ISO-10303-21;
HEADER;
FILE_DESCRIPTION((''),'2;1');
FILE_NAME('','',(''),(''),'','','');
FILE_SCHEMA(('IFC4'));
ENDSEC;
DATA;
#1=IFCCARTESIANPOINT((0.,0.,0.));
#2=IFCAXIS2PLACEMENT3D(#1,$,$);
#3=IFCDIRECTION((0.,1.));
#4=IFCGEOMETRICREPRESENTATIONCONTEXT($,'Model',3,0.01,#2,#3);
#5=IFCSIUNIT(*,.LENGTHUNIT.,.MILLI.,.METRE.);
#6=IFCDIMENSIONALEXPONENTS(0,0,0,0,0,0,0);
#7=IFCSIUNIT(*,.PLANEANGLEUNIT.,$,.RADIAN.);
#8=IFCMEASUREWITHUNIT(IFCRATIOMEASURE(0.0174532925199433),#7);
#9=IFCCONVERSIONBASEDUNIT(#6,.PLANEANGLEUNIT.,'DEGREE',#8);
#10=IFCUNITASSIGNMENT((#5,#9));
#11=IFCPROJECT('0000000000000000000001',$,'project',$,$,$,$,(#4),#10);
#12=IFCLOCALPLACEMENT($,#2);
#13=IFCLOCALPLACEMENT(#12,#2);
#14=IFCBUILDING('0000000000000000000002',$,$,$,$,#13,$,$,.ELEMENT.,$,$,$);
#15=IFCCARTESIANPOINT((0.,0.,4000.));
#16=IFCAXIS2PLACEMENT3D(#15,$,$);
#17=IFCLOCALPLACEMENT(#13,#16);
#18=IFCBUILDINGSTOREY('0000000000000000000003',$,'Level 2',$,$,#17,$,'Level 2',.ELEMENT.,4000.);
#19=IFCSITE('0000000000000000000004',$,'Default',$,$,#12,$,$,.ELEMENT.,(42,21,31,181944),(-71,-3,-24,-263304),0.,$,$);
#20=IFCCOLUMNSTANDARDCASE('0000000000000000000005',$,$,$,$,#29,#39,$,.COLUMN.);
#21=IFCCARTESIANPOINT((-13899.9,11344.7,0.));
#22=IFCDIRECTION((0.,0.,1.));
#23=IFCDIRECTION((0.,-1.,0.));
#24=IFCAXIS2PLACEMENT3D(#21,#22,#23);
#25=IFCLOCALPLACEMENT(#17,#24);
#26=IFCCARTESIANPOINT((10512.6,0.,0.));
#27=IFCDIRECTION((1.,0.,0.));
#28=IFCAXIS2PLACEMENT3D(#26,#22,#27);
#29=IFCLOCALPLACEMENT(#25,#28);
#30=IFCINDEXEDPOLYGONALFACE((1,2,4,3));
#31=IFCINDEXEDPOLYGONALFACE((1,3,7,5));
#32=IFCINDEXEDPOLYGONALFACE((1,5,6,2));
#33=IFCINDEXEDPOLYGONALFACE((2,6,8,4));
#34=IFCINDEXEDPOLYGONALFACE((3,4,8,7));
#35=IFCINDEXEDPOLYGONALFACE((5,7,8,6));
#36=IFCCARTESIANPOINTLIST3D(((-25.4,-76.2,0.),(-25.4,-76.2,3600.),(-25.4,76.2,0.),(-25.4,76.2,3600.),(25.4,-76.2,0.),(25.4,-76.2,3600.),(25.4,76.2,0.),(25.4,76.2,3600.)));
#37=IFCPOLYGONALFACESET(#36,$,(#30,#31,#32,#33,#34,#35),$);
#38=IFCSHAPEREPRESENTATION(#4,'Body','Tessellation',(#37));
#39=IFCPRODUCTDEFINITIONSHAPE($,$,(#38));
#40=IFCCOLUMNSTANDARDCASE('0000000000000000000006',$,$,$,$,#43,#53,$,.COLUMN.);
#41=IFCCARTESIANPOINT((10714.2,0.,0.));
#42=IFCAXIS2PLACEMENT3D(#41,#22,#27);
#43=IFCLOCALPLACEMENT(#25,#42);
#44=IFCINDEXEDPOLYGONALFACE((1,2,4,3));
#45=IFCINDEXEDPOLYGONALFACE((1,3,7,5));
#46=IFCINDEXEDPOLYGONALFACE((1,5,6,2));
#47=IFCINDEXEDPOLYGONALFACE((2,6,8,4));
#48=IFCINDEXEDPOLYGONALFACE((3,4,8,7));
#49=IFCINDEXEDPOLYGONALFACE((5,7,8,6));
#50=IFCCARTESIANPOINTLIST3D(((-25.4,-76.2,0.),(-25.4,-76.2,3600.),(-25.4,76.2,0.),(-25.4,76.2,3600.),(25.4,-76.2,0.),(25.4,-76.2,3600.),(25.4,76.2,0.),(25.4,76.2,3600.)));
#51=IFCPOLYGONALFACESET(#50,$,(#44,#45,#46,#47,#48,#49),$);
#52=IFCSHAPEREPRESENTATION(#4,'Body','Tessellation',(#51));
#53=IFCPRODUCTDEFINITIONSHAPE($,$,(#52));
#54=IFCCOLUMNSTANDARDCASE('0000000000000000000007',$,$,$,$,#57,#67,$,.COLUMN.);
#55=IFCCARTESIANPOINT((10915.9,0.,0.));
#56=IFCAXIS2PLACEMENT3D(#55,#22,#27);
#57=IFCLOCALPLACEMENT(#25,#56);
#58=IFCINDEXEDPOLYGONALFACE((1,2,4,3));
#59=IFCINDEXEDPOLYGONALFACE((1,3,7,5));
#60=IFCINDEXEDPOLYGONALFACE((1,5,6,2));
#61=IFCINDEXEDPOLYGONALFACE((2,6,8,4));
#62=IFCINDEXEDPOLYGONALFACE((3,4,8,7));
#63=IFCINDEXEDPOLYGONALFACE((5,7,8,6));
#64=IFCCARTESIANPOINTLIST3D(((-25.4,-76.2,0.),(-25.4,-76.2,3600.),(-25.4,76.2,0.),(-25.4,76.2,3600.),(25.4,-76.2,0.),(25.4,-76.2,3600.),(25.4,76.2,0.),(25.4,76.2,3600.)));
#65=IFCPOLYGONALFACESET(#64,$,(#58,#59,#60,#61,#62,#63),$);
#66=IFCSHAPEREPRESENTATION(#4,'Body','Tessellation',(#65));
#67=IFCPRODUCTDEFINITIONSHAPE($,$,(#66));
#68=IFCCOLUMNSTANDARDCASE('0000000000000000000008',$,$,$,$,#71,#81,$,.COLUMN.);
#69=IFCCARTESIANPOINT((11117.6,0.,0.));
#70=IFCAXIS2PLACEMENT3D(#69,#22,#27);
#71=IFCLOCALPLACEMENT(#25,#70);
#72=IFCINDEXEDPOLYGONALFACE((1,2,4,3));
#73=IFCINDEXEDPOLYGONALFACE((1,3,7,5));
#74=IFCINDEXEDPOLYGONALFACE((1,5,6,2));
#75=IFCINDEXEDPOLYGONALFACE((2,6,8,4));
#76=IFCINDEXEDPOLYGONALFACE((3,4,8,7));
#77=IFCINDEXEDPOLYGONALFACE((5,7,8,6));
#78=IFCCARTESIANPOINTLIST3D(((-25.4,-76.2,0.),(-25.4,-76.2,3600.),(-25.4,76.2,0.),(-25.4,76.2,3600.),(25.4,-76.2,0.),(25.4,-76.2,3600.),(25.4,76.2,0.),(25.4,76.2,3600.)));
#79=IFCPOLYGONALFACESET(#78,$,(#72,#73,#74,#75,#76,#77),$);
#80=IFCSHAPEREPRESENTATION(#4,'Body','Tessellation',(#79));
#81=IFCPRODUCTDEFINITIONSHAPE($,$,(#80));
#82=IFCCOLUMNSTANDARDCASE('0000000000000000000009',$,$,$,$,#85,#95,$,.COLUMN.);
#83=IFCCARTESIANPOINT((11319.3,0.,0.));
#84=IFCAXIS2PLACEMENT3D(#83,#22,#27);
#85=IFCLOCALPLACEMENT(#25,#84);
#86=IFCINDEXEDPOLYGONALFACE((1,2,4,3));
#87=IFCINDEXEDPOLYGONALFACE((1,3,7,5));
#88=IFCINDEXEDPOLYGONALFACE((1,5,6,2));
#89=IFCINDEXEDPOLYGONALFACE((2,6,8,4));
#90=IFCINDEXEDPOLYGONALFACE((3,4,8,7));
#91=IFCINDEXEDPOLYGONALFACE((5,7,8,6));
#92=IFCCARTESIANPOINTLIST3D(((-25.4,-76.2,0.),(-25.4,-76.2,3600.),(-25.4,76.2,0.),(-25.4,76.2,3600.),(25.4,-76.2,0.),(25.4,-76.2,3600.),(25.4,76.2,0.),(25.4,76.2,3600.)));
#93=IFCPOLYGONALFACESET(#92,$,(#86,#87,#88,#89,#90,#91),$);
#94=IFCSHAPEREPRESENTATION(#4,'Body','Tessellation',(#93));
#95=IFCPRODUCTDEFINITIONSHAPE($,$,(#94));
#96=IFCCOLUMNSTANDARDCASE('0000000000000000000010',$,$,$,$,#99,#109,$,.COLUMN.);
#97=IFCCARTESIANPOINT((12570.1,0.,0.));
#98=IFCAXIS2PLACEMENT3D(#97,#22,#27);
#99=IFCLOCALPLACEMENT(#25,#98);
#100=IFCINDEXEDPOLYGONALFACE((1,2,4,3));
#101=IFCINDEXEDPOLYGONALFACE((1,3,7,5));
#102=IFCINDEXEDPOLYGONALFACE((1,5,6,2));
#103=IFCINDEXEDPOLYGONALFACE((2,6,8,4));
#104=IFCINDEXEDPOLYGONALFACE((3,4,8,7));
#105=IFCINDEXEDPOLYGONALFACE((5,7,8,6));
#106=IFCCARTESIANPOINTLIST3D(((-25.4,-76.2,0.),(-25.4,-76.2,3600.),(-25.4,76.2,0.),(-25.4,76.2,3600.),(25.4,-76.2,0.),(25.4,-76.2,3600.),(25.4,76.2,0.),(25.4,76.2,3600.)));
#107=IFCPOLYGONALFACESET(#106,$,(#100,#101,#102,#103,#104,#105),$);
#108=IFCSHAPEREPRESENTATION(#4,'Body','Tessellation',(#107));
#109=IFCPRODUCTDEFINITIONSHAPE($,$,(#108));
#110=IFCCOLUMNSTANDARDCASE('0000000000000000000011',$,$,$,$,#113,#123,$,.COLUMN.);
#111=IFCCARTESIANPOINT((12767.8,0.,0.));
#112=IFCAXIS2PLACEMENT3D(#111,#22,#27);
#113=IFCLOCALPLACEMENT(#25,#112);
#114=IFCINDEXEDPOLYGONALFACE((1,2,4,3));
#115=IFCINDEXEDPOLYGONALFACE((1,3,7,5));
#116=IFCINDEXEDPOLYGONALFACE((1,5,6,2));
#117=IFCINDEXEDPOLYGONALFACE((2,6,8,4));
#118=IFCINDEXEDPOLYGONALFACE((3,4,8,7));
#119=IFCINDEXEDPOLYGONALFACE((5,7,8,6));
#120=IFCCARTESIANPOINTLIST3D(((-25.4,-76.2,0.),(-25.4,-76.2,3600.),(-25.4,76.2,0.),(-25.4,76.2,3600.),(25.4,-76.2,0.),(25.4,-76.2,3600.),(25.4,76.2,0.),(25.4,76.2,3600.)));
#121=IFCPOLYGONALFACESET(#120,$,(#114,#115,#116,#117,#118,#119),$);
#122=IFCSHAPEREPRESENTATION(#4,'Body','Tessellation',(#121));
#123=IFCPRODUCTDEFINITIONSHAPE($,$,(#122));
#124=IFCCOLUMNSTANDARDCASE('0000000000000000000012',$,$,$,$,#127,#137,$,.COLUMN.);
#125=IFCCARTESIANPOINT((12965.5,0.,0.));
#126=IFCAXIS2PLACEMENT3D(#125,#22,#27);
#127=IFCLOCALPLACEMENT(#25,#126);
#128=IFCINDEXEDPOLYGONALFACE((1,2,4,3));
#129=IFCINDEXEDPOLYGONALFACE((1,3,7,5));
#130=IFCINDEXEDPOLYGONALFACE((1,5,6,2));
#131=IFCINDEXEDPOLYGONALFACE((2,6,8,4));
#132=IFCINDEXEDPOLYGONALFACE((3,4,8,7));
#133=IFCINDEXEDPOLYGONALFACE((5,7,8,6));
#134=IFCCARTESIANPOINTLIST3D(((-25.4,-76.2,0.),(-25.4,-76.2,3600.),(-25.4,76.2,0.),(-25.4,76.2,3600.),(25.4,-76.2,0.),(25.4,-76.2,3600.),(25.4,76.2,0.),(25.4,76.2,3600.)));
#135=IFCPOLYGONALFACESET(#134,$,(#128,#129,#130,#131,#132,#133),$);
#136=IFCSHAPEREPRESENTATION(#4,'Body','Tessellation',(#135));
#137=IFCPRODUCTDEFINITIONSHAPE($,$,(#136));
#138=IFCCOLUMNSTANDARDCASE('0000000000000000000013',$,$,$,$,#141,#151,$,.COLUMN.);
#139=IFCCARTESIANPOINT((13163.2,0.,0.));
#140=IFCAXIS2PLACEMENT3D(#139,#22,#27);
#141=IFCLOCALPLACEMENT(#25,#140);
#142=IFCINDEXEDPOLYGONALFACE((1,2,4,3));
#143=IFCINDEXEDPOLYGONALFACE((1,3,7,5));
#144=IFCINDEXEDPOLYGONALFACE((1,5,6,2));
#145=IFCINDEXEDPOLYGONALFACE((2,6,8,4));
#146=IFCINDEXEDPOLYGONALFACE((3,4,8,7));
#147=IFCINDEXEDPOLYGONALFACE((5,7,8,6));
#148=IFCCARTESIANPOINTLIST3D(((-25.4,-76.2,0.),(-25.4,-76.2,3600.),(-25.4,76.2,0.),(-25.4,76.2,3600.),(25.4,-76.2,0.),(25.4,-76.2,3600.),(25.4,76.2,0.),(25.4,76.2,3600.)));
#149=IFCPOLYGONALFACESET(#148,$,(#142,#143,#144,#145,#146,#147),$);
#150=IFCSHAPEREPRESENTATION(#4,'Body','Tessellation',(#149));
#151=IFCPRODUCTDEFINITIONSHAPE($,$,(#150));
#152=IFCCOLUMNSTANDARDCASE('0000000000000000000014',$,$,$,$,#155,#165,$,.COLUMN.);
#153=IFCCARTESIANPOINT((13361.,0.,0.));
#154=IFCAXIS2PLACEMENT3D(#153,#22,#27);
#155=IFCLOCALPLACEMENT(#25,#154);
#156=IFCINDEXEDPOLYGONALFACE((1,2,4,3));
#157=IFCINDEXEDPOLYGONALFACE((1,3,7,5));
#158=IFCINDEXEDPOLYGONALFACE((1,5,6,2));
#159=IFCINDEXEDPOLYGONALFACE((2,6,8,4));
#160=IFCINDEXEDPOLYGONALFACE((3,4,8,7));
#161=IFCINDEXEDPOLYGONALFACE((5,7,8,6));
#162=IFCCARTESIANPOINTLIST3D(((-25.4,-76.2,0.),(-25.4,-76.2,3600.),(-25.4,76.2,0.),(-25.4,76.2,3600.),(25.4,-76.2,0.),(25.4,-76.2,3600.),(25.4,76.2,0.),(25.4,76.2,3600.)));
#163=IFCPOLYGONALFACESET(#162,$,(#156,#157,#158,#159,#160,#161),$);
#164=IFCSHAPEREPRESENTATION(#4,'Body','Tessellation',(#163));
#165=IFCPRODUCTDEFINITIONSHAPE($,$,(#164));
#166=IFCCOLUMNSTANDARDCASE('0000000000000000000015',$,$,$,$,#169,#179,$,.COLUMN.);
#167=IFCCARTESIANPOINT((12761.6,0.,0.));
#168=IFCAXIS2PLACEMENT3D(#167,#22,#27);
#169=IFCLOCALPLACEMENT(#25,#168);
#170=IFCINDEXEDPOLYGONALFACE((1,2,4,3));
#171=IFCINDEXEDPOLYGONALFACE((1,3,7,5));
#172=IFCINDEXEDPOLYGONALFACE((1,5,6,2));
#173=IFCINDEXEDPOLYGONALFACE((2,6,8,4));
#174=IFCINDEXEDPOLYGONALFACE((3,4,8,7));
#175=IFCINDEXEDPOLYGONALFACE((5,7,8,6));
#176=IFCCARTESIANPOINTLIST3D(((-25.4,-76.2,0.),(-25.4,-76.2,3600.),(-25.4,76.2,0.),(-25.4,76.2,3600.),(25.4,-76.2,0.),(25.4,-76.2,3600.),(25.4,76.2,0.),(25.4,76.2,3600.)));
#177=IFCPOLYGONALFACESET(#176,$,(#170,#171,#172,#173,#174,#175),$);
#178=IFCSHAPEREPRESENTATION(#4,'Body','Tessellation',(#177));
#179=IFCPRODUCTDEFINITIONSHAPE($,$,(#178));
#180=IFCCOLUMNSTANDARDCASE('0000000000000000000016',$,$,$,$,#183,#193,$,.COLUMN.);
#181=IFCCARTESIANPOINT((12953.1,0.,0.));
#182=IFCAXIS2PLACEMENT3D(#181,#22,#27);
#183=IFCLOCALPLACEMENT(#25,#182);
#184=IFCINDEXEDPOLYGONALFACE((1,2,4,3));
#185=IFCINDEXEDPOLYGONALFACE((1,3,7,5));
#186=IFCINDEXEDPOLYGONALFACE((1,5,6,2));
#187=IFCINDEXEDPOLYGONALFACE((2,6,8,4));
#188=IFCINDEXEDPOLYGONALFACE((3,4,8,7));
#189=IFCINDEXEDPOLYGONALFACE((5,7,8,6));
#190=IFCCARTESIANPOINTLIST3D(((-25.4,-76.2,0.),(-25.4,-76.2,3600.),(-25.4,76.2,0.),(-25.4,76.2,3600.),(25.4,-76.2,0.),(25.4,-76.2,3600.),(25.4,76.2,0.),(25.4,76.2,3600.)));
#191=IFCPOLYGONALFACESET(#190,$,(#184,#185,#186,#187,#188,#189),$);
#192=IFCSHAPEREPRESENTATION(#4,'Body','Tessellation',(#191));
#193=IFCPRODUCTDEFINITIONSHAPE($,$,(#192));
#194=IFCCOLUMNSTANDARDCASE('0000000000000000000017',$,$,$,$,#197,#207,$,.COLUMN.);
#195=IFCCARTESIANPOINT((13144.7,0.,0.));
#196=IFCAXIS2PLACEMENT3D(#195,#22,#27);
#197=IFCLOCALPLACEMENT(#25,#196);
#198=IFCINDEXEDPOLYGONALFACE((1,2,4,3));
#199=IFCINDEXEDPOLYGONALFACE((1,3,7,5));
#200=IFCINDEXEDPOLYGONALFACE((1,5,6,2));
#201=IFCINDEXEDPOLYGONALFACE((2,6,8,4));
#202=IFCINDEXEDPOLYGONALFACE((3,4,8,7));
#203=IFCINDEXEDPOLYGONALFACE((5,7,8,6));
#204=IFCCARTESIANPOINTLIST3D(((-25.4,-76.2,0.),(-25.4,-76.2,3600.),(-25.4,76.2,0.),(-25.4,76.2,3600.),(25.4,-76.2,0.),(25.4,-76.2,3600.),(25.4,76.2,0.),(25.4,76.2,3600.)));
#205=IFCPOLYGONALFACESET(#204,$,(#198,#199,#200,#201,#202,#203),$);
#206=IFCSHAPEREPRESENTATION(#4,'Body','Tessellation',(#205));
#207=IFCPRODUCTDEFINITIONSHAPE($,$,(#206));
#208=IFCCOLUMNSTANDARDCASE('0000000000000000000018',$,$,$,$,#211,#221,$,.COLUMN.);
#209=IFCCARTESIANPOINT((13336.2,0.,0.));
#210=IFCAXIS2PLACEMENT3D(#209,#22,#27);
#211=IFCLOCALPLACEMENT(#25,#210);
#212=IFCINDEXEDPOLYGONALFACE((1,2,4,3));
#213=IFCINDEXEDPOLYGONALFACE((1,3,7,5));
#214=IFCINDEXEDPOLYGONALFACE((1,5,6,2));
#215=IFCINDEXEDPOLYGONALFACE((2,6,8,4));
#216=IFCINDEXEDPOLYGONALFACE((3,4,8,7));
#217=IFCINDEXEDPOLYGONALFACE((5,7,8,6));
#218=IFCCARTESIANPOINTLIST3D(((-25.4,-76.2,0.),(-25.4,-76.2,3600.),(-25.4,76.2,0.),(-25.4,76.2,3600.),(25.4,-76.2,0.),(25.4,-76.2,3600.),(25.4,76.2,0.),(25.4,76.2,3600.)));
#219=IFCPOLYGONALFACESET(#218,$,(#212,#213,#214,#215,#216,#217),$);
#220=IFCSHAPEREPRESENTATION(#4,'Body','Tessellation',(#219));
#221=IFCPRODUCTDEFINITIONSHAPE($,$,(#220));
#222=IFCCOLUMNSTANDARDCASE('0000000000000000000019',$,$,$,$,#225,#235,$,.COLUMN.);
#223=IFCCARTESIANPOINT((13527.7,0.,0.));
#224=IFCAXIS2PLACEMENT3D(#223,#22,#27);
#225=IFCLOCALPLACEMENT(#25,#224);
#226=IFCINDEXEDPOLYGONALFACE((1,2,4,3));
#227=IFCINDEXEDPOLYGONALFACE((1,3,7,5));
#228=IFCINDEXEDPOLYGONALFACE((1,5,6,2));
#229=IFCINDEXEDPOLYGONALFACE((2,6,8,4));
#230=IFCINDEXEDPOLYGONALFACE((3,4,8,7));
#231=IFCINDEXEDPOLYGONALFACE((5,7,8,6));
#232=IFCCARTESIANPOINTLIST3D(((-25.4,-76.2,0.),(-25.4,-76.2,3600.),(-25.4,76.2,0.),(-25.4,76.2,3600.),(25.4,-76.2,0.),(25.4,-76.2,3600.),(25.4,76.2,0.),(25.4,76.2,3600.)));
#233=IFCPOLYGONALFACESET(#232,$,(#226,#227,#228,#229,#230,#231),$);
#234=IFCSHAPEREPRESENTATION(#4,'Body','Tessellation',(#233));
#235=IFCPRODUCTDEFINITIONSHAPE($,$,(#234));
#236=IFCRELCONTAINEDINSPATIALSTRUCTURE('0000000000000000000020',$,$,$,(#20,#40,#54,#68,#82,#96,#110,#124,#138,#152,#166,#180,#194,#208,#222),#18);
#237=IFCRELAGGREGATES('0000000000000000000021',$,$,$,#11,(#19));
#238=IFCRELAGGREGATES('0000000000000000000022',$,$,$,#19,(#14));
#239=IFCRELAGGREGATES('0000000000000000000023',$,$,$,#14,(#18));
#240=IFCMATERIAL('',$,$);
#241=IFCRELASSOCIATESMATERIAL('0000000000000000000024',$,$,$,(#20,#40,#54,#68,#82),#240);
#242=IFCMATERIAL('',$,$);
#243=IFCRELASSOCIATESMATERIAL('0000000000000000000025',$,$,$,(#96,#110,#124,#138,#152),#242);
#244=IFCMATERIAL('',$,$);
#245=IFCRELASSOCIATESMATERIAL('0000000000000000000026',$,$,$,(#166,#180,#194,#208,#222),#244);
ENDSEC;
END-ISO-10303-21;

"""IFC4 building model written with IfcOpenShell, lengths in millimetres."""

from ifc_helpers import new_model, entity, si_unit, converted_unit, direction, frame, origin, place, context, project, spatial, rectangle, extrude, material, element, save


model = new_model("IFC4")

# Units and contexts
model_context = context("Model", 3, precision=0.01, world=origin(), true_north=direction((0.0, 1.0)))
ifc_project = project(units=[si_unit("LENGTHUNIT", "METRE", prefix="MILLI"), converted_unit("PLANEANGLEUNIT", "DEGREE", entity("IfcRatioMeasure", 0.0174532925199433), si_unit("PLANEANGLEUNIT", "RADIAN"), dimensions=[0, 0, 0, 0, 0, 0, 0])], contexts=[model_context])

# Site, building, storey
site_placement = place(None, origin())
site = spatial("IfcSite", under=ifc_project, at=site_placement, Name="Default", CompositionType="ELEMENT", RefLatitude=(42, 21, 31, 181944), RefLongitude=(-71, -3, -24, -263304), RefElevation=0.0)
building_placement = place(site_placement, origin())
building = spatial("IfcBuilding", under=site, at=building_placement, CompositionType="ELEMENT")
storey_placement = place(building_placement, frame((0.0, 0.0, 4000.0)))
storey = spatial("IfcBuildingStorey", under=building, at=storey_placement, Name="Level 2", LongName="Level 2", CompositionType="ELEMENT", Elevation=4000.0)

# Columns
ifc_material_1 = material(Name="")
placement = place(storey_placement, frame((-13899.9, 11344.7, 0.0), z_axis=(0.0, 0.0, 1.0), x_axis=(0.0, -1.0, 0.0)))
for number, where, z_axis, x_axis in (
    (1, (10512.6, 0.0, 0.0), (0.0, 0.0, 1.0), (1.0, 0.0, 0.0)),
    (2, (10714.2, 0.0, 0.0), (0.0, 0.0, 1.0), (1.0, 0.0, 0.0)),
    (3, (10915.9, 0.0, 0.0), (0.0, 0.0, 1.0), (1.0, 0.0, 0.0)),
    (4, (11117.6, 0.0, 0.0), (0.0, 0.0, 1.0), (1.0, 0.0, 0.0)),
    (5, (11319.3, 0.0, 0.0), (0.0, 0.0, 1.0), (1.0, 0.0, 0.0)),
):
    element("IfcColumnStandardCase", number, at=place(placement, frame(where, z_axis=z_axis, x_axis=x_axis)), inside=storey, material=ifc_material_1, PredefinedType="COLUMN", context=model_context, shape_type="SweptSolid", body=[
        extrude(rectangle(XDim=50.8, YDim=152.4), origin(), (0.0, 0.0, 1.0), 3600.0),
    ])
ifc_material_2 = material(Name="")
for number, where, z_axis, x_axis in (
    (6, (12570.1, 0.0, 0.0), (0.0, 0.0, 1.0), (1.0, 0.0, 0.0)),
    (7, (12767.8, 0.0, 0.0), (0.0, 0.0, 1.0), (1.0, 0.0, 0.0)),
    (8, (12965.5, 0.0, 0.0), (0.0, 0.0, 1.0), (1.0, 0.0, 0.0)),
    (9, (13163.2, 0.0, 0.0), (0.0, 0.0, 1.0), (1.0, 0.0, 0.0)),
    (10, (13361.0, 0.0, 0.0), (0.0, 0.0, 1.0), (1.0, 0.0, 0.0)),
):
    element("IfcColumnStandardCase", number, at=place(placement, frame(where, z_axis=z_axis, x_axis=x_axis)), inside=storey, material=ifc_material_2, PredefinedType="COLUMN", context=model_context, shape_type="SweptSolid", body=[
        extrude(rectangle(XDim=50.8, YDim=152.4), origin(), (0.0, 0.0, 1.0), 3600.0),
    ])
ifc_material_3 = material(Name="")
for number, where, z_axis, x_axis in (
    (11, (12761.6, 0.0, 0.0), (0.0, 0.0, 1.0), (1.0, 0.0, 0.0)),
    (12, (12953.1, 0.0, 0.0), (0.0, 0.0, 1.0), (1.0, 0.0, 0.0)),
    (13, (13144.7, 0.0, 0.0), (0.0, 0.0, 1.0), (1.0, 0.0, 0.0)),
    (14, (13336.2, 0.0, 0.0), (0.0, 0.0, 1.0), (1.0, 0.0, 0.0)),
    (15, (13527.7, 0.0, 0.0), (0.0, 0.0, 1.0), (1.0, 0.0, 0.0)),
):
    element("IfcColumnStandardCase", number, at=place(placement, frame(where, z_axis=z_axis, x_axis=x_axis)), inside=storey, material=ifc_material_3, PredefinedType="COLUMN", context=model_context, shape_type="SweptSolid", body=[
        extrude(rectangle(XDim=50.8, YDim=152.4), origin(), (0.0, 0.0, 1.0), 3600.0),
    ])

save(model, "model.ifc")
